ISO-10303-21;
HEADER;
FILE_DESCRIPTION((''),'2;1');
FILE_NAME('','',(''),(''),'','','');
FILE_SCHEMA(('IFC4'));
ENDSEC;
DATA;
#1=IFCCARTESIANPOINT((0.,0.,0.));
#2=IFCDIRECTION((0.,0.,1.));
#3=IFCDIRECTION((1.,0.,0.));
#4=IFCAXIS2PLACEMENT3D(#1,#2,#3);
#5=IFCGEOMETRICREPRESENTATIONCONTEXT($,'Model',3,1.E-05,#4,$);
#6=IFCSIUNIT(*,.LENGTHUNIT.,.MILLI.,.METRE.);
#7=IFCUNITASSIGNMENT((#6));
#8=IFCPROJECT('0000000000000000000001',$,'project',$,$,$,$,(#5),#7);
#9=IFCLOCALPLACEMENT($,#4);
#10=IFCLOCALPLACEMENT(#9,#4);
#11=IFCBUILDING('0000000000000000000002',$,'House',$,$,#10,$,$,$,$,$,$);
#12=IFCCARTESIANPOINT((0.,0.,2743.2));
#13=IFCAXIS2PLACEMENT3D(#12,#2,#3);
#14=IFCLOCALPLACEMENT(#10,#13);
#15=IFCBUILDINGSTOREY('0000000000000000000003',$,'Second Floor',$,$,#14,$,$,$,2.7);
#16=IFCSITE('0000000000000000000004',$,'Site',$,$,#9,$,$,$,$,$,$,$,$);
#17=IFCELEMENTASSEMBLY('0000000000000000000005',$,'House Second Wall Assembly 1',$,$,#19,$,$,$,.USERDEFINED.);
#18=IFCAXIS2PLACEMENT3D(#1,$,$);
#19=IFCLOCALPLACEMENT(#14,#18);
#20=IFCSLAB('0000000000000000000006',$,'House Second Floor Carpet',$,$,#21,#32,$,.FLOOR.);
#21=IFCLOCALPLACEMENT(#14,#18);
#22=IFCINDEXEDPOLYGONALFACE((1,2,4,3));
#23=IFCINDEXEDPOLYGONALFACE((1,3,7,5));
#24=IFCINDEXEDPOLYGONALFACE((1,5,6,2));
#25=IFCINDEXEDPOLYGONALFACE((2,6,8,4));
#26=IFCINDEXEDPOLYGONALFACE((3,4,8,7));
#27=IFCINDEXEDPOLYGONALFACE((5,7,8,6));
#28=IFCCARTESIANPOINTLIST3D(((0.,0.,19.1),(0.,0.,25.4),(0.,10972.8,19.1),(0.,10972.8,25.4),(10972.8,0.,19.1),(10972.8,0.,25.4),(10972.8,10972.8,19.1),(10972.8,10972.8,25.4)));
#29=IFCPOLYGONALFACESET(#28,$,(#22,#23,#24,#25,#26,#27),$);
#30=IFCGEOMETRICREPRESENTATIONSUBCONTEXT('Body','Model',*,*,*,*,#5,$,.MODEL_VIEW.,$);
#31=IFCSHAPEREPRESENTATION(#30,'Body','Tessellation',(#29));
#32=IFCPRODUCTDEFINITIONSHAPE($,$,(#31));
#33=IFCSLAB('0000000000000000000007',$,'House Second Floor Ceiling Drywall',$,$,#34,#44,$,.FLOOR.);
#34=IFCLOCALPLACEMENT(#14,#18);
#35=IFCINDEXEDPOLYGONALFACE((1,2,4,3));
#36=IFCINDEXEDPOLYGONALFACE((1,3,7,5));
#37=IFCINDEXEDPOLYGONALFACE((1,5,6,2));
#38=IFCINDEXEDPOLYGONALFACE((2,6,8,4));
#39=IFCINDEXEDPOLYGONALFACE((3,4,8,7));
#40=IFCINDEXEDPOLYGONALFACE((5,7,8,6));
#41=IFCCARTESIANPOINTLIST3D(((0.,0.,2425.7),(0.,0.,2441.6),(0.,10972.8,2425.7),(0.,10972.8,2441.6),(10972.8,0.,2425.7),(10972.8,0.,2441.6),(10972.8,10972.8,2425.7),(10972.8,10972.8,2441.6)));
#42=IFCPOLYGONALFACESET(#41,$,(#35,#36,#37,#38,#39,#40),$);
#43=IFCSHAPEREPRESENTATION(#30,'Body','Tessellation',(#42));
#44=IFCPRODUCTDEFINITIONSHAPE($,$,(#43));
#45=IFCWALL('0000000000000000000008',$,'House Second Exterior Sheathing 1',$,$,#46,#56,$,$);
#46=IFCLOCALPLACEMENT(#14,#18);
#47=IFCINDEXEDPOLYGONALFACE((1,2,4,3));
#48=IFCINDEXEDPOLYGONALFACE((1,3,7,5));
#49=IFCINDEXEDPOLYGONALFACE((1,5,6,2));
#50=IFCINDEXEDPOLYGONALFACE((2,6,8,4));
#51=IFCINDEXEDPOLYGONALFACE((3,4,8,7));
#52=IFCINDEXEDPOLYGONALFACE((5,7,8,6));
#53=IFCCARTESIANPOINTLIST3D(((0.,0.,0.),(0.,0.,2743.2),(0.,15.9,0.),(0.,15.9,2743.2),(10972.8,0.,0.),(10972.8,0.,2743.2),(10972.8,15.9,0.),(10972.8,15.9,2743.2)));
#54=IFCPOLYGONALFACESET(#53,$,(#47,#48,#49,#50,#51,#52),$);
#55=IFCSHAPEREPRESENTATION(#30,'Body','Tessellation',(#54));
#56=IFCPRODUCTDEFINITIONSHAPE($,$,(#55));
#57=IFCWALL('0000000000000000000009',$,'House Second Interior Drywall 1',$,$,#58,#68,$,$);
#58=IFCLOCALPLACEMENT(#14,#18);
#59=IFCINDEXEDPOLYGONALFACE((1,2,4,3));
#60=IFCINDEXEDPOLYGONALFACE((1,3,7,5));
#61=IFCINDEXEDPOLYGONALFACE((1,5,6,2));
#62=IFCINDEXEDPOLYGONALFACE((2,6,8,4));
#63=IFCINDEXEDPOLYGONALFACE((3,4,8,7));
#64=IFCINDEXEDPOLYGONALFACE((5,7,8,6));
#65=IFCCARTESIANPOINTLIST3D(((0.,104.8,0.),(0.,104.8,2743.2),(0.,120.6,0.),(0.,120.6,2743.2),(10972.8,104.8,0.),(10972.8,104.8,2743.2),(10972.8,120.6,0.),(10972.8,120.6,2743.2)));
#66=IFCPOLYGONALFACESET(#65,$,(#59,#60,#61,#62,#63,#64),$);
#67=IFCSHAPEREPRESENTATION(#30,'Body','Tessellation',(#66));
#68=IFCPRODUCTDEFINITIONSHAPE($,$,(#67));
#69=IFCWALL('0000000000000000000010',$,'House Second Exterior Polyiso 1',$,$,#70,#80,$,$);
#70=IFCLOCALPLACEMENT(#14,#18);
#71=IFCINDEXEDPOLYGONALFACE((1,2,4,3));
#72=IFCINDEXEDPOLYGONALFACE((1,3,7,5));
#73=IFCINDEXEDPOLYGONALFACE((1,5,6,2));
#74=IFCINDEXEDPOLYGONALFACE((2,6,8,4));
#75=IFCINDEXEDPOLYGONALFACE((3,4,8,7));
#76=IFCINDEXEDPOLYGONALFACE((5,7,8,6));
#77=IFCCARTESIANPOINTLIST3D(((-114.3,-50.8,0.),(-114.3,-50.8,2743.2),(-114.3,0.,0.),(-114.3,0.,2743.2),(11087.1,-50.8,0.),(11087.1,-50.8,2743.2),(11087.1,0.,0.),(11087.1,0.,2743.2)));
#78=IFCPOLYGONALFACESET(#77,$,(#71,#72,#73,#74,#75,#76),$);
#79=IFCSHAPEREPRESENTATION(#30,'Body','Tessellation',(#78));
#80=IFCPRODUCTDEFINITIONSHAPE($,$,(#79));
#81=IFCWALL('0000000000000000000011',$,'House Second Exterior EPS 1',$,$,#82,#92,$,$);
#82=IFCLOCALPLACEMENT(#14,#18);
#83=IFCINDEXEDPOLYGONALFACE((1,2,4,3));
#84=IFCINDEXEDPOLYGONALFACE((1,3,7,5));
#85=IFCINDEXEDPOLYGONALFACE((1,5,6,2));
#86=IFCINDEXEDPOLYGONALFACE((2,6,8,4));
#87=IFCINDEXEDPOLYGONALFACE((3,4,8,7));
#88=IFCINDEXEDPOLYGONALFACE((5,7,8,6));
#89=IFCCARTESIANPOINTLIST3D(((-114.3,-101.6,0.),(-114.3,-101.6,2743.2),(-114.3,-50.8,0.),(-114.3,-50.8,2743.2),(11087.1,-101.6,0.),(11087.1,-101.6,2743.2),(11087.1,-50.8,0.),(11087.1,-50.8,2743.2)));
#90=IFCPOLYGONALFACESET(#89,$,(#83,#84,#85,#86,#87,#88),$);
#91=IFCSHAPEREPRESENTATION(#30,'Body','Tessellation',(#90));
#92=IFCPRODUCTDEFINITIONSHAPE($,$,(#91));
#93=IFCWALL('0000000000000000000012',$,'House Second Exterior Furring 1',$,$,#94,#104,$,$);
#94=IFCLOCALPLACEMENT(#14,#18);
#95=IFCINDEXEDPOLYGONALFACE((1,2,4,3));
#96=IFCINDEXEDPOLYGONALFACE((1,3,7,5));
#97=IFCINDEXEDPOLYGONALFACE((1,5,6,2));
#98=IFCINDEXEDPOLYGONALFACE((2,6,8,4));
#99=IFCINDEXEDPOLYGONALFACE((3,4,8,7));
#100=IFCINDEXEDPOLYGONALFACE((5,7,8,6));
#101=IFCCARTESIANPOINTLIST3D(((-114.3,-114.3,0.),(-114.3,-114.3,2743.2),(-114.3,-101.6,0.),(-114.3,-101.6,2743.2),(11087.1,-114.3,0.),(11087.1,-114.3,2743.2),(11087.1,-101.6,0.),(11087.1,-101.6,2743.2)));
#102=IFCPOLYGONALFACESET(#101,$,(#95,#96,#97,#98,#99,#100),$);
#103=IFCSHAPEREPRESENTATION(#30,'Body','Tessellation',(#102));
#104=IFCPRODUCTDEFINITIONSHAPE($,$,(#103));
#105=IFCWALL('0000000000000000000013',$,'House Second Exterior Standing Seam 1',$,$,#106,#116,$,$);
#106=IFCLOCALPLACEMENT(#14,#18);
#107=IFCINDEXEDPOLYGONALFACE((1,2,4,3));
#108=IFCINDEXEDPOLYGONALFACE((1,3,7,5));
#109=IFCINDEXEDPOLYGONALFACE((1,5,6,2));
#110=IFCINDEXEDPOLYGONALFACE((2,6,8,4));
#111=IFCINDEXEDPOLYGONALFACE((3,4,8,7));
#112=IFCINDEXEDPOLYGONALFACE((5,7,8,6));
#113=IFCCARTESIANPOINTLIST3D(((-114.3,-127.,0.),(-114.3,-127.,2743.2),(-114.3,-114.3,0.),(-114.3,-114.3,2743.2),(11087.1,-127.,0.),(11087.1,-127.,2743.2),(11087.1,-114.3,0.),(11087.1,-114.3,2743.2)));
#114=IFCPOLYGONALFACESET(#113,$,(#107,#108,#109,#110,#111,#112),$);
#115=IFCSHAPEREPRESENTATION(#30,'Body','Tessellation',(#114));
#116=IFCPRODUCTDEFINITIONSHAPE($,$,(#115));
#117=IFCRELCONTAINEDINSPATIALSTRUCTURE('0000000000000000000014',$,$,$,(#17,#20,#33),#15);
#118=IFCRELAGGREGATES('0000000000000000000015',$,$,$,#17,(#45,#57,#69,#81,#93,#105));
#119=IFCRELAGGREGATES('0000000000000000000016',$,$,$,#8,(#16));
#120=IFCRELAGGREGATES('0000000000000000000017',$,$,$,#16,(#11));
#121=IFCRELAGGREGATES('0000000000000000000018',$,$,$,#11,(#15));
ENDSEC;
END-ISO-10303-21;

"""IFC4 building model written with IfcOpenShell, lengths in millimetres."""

from ifc_helpers import new_model, si_unit, frame, origin_with_axes, place, context, subcontext, project, spatial, indexed_curve, outline, extrude, element, aggregate, save


model = new_model("IFC4")

# Units and contexts
model_context = context("Model", 3, precision=1e-05, world=origin_with_axes())
body_context = subcontext(model_context, "Body", "Model", "MODEL_VIEW")
ifc_project = project(units=[si_unit("LENGTHUNIT", "METRE", prefix="MILLI")], contexts=[model_context])

# Site, building, storey
site_placement = place(None, origin_with_axes())
site = spatial("IfcSite", under=ifc_project, at=site_placement, Name="Site")
building_placement = place(site_placement, origin_with_axes())
building = spatial("IfcBuilding", under=site, at=building_placement, Name="House")
storey_placement = place(building_placement, frame((0.0, 0.0, 2743.2), z_axis=(0.0, 0.0, 1.0), x_axis=(1.0, 0.0, 0.0)))
storey = spatial("IfcBuildingStorey", under=building, at=storey_placement, Name="Second Floor", Elevation=2.7)

# Element assembly
assembly_1_placement = place(storey_placement, frame((0.0, 0.0, -2743.2), z_axis=(0.0, 0.0, 1.0), x_axis=(1.0, 0.0, 0.0)))
assembly_1 = element("IfcElementAssembly", 1, at=assembly_1_placement, inside=storey, Name="House Second Wall Assembly 1", PredefinedType="USERDEFINED")

# Slabs
slab_1_placement = place(storey_placement, frame((0.0, 0.0, 19.1), z_axis=(0.0, 0.0, 1.0), x_axis=(1.0, 0.0, 0.0)))
element("IfcSlab", 2, at=slab_1_placement, inside=storey, Name="House Second Floor Carpet", PredefinedType="FLOOR", context=body_context, shape_type="SweptSolid", body=[
    extrude(outline(indexed_curve([(0.0, 0.0), (10972.8, 0.0), (10972.8, 10972.8), (0.0, 10972.8), (0.0, 0.0)])), None, (0.0, 0.0, 1.0), 6.3),
])
slab_2_placement = place(storey_placement, frame((0.0, 0.0, 2425.7), z_axis=(0.0, 0.0, 1.0), x_axis=(1.0, 0.0, 0.0)))
element("IfcSlab", 3, at=slab_2_placement, inside=storey, Name="House Second Floor Ceiling Drywall", PredefinedType="FLOOR", context=body_context, shape_type="SweptSolid", body=[
    extrude(outline(indexed_curve([(0.0, 0.0), (10972.8, 0.0), (10972.8, 10972.8), (0.0, 10972.8), (0.0, 0.0)])), None, (0.0, 0.0, 1.0), 15.9),
])

# Walls
wall_1_placement = place(assembly_1_placement, frame((0.0, 0.0, 2743.2), z_axis=(0.0, 0.0, 1.0), x_axis=(1.0, 0.0, 0.0)))
wall_1 = element("IfcWall", 4, at=wall_1_placement, Name="House Second Exterior Sheathing 1", context=body_context, shape_type="SweptSolid", body=[
    extrude(outline(indexed_curve([(0.0, 0.0), (0.0, 15.9), (10972.8, 15.9), (10972.8, 0.0), (0.0, 0.0)], self_intersect=False)), origin_with_axes(), (0.0, 0.0, 1.0), 2743.2),
])
wall_2_placement = place(assembly_1_placement, frame((0.0, 0.0, 2743.2), z_axis=(0.0, 0.0, 1.0), x_axis=(1.0, 0.0, 0.0)))
wall_2 = element("IfcWall", 5, at=wall_2_placement, Name="House Second Interior Drywall 1", context=body_context, shape_type="SweptSolid", body=[
    extrude(outline(indexed_curve([(0.0, 0.0), (0.0, 15.9), (10972.8, 15.9), (10972.8, 0.0), (0.0, 0.0)], self_intersect=False)), frame((0.0, 104.8, 0.0), z_axis=(0.0, 0.0, 1.0), x_axis=(1.0, 0.0, 0.0)), (0.0, 0.0, 1.0), 2743.2),
])
wall_3_placement = place(assembly_1_placement, frame((-114.3, 0.0, 2743.2), z_axis=(0.0, 0.0, 1.0), x_axis=(1.0, 0.0, 0.0)))
wall_3 = element("IfcWall", 6, at=wall_3_placement, Name="House Second Exterior Polyiso 1", context=body_context, shape_type="SweptSolid", body=[
    extrude(outline(indexed_curve([(0.0, 0.0), (0.0, -50.8), (11201.4, -50.8), (11201.4, 0.0), (0.0, 0.0)], self_intersect=False)), origin_with_axes(), (0.0, 0.0, 1.0), 2743.2),
])
wall_4_placement = place(assembly_1_placement, frame((-114.3, 0.0, 2743.2), z_axis=(0.0, 0.0, 1.0), x_axis=(1.0, 0.0, 0.0)))
wall_4 = element("IfcWall", 7, at=wall_4_placement, Name="House Second Exterior EPS 1", context=body_context, shape_type="SweptSolid", body=[
    extrude(outline(indexed_curve([(0.0, 0.0), (0.0, -50.8), (11201.4, -50.8), (11201.4, 0.0), (0.0, 0.0)], self_intersect=False)), frame((0.0, -50.8, 0.0), z_axis=(0.0, 0.0, 1.0), x_axis=(1.0, 0.0, 0.0)), (0.0, 0.0, 1.0), 2743.2),
])
wall_5_placement = place(assembly_1_placement, frame((-114.3, 0.0, 2743.2), z_axis=(0.0, 0.0, 1.0), x_axis=(1.0, 0.0, 0.0)))
wall_5 = element("IfcWall", 8, at=wall_5_placement, Name="House Second Exterior Furring 1", context=body_context, shape_type="SweptSolid", body=[
    extrude(outline(indexed_curve([(0.0, 0.0), (0.0, -12.7), (11201.4, -12.7), (11201.4, 0.0), (0.0, 0.0)], self_intersect=False)), frame((0.0, -101.6, 0.0), z_axis=(0.0, 0.0, 1.0), x_axis=(1.0, 0.0, 0.0)), (0.0, 0.0, 1.0), 2743.2),
])
wall_6_placement = place(assembly_1_placement, frame((-114.3, 0.0, 2743.2), z_axis=(0.0, 0.0, 1.0), x_axis=(1.0, 0.0, 0.0)))
wall_6 = element("IfcWall", 9, at=wall_6_placement, Name="House Second Exterior Standing Seam 1", context=body_context, shape_type="SweptSolid", body=[
    extrude(outline(indexed_curve([(0.0, 0.0), (0.0, -12.7), (11201.4, -12.7), (11201.4, 0.0), (0.0, 0.0)], self_intersect=False)), frame((0.0, -114.3, 0.0), z_axis=(0.0, 0.0, 1.0), x_axis=(1.0, 0.0, 0.0)), (0.0, 0.0, 1.0), 2743.2),
])
aggregate(assembly_1, [wall_1, wall_2, wall_3, wall_4, wall_5, wall_6])

save(model, "model.ifc")
